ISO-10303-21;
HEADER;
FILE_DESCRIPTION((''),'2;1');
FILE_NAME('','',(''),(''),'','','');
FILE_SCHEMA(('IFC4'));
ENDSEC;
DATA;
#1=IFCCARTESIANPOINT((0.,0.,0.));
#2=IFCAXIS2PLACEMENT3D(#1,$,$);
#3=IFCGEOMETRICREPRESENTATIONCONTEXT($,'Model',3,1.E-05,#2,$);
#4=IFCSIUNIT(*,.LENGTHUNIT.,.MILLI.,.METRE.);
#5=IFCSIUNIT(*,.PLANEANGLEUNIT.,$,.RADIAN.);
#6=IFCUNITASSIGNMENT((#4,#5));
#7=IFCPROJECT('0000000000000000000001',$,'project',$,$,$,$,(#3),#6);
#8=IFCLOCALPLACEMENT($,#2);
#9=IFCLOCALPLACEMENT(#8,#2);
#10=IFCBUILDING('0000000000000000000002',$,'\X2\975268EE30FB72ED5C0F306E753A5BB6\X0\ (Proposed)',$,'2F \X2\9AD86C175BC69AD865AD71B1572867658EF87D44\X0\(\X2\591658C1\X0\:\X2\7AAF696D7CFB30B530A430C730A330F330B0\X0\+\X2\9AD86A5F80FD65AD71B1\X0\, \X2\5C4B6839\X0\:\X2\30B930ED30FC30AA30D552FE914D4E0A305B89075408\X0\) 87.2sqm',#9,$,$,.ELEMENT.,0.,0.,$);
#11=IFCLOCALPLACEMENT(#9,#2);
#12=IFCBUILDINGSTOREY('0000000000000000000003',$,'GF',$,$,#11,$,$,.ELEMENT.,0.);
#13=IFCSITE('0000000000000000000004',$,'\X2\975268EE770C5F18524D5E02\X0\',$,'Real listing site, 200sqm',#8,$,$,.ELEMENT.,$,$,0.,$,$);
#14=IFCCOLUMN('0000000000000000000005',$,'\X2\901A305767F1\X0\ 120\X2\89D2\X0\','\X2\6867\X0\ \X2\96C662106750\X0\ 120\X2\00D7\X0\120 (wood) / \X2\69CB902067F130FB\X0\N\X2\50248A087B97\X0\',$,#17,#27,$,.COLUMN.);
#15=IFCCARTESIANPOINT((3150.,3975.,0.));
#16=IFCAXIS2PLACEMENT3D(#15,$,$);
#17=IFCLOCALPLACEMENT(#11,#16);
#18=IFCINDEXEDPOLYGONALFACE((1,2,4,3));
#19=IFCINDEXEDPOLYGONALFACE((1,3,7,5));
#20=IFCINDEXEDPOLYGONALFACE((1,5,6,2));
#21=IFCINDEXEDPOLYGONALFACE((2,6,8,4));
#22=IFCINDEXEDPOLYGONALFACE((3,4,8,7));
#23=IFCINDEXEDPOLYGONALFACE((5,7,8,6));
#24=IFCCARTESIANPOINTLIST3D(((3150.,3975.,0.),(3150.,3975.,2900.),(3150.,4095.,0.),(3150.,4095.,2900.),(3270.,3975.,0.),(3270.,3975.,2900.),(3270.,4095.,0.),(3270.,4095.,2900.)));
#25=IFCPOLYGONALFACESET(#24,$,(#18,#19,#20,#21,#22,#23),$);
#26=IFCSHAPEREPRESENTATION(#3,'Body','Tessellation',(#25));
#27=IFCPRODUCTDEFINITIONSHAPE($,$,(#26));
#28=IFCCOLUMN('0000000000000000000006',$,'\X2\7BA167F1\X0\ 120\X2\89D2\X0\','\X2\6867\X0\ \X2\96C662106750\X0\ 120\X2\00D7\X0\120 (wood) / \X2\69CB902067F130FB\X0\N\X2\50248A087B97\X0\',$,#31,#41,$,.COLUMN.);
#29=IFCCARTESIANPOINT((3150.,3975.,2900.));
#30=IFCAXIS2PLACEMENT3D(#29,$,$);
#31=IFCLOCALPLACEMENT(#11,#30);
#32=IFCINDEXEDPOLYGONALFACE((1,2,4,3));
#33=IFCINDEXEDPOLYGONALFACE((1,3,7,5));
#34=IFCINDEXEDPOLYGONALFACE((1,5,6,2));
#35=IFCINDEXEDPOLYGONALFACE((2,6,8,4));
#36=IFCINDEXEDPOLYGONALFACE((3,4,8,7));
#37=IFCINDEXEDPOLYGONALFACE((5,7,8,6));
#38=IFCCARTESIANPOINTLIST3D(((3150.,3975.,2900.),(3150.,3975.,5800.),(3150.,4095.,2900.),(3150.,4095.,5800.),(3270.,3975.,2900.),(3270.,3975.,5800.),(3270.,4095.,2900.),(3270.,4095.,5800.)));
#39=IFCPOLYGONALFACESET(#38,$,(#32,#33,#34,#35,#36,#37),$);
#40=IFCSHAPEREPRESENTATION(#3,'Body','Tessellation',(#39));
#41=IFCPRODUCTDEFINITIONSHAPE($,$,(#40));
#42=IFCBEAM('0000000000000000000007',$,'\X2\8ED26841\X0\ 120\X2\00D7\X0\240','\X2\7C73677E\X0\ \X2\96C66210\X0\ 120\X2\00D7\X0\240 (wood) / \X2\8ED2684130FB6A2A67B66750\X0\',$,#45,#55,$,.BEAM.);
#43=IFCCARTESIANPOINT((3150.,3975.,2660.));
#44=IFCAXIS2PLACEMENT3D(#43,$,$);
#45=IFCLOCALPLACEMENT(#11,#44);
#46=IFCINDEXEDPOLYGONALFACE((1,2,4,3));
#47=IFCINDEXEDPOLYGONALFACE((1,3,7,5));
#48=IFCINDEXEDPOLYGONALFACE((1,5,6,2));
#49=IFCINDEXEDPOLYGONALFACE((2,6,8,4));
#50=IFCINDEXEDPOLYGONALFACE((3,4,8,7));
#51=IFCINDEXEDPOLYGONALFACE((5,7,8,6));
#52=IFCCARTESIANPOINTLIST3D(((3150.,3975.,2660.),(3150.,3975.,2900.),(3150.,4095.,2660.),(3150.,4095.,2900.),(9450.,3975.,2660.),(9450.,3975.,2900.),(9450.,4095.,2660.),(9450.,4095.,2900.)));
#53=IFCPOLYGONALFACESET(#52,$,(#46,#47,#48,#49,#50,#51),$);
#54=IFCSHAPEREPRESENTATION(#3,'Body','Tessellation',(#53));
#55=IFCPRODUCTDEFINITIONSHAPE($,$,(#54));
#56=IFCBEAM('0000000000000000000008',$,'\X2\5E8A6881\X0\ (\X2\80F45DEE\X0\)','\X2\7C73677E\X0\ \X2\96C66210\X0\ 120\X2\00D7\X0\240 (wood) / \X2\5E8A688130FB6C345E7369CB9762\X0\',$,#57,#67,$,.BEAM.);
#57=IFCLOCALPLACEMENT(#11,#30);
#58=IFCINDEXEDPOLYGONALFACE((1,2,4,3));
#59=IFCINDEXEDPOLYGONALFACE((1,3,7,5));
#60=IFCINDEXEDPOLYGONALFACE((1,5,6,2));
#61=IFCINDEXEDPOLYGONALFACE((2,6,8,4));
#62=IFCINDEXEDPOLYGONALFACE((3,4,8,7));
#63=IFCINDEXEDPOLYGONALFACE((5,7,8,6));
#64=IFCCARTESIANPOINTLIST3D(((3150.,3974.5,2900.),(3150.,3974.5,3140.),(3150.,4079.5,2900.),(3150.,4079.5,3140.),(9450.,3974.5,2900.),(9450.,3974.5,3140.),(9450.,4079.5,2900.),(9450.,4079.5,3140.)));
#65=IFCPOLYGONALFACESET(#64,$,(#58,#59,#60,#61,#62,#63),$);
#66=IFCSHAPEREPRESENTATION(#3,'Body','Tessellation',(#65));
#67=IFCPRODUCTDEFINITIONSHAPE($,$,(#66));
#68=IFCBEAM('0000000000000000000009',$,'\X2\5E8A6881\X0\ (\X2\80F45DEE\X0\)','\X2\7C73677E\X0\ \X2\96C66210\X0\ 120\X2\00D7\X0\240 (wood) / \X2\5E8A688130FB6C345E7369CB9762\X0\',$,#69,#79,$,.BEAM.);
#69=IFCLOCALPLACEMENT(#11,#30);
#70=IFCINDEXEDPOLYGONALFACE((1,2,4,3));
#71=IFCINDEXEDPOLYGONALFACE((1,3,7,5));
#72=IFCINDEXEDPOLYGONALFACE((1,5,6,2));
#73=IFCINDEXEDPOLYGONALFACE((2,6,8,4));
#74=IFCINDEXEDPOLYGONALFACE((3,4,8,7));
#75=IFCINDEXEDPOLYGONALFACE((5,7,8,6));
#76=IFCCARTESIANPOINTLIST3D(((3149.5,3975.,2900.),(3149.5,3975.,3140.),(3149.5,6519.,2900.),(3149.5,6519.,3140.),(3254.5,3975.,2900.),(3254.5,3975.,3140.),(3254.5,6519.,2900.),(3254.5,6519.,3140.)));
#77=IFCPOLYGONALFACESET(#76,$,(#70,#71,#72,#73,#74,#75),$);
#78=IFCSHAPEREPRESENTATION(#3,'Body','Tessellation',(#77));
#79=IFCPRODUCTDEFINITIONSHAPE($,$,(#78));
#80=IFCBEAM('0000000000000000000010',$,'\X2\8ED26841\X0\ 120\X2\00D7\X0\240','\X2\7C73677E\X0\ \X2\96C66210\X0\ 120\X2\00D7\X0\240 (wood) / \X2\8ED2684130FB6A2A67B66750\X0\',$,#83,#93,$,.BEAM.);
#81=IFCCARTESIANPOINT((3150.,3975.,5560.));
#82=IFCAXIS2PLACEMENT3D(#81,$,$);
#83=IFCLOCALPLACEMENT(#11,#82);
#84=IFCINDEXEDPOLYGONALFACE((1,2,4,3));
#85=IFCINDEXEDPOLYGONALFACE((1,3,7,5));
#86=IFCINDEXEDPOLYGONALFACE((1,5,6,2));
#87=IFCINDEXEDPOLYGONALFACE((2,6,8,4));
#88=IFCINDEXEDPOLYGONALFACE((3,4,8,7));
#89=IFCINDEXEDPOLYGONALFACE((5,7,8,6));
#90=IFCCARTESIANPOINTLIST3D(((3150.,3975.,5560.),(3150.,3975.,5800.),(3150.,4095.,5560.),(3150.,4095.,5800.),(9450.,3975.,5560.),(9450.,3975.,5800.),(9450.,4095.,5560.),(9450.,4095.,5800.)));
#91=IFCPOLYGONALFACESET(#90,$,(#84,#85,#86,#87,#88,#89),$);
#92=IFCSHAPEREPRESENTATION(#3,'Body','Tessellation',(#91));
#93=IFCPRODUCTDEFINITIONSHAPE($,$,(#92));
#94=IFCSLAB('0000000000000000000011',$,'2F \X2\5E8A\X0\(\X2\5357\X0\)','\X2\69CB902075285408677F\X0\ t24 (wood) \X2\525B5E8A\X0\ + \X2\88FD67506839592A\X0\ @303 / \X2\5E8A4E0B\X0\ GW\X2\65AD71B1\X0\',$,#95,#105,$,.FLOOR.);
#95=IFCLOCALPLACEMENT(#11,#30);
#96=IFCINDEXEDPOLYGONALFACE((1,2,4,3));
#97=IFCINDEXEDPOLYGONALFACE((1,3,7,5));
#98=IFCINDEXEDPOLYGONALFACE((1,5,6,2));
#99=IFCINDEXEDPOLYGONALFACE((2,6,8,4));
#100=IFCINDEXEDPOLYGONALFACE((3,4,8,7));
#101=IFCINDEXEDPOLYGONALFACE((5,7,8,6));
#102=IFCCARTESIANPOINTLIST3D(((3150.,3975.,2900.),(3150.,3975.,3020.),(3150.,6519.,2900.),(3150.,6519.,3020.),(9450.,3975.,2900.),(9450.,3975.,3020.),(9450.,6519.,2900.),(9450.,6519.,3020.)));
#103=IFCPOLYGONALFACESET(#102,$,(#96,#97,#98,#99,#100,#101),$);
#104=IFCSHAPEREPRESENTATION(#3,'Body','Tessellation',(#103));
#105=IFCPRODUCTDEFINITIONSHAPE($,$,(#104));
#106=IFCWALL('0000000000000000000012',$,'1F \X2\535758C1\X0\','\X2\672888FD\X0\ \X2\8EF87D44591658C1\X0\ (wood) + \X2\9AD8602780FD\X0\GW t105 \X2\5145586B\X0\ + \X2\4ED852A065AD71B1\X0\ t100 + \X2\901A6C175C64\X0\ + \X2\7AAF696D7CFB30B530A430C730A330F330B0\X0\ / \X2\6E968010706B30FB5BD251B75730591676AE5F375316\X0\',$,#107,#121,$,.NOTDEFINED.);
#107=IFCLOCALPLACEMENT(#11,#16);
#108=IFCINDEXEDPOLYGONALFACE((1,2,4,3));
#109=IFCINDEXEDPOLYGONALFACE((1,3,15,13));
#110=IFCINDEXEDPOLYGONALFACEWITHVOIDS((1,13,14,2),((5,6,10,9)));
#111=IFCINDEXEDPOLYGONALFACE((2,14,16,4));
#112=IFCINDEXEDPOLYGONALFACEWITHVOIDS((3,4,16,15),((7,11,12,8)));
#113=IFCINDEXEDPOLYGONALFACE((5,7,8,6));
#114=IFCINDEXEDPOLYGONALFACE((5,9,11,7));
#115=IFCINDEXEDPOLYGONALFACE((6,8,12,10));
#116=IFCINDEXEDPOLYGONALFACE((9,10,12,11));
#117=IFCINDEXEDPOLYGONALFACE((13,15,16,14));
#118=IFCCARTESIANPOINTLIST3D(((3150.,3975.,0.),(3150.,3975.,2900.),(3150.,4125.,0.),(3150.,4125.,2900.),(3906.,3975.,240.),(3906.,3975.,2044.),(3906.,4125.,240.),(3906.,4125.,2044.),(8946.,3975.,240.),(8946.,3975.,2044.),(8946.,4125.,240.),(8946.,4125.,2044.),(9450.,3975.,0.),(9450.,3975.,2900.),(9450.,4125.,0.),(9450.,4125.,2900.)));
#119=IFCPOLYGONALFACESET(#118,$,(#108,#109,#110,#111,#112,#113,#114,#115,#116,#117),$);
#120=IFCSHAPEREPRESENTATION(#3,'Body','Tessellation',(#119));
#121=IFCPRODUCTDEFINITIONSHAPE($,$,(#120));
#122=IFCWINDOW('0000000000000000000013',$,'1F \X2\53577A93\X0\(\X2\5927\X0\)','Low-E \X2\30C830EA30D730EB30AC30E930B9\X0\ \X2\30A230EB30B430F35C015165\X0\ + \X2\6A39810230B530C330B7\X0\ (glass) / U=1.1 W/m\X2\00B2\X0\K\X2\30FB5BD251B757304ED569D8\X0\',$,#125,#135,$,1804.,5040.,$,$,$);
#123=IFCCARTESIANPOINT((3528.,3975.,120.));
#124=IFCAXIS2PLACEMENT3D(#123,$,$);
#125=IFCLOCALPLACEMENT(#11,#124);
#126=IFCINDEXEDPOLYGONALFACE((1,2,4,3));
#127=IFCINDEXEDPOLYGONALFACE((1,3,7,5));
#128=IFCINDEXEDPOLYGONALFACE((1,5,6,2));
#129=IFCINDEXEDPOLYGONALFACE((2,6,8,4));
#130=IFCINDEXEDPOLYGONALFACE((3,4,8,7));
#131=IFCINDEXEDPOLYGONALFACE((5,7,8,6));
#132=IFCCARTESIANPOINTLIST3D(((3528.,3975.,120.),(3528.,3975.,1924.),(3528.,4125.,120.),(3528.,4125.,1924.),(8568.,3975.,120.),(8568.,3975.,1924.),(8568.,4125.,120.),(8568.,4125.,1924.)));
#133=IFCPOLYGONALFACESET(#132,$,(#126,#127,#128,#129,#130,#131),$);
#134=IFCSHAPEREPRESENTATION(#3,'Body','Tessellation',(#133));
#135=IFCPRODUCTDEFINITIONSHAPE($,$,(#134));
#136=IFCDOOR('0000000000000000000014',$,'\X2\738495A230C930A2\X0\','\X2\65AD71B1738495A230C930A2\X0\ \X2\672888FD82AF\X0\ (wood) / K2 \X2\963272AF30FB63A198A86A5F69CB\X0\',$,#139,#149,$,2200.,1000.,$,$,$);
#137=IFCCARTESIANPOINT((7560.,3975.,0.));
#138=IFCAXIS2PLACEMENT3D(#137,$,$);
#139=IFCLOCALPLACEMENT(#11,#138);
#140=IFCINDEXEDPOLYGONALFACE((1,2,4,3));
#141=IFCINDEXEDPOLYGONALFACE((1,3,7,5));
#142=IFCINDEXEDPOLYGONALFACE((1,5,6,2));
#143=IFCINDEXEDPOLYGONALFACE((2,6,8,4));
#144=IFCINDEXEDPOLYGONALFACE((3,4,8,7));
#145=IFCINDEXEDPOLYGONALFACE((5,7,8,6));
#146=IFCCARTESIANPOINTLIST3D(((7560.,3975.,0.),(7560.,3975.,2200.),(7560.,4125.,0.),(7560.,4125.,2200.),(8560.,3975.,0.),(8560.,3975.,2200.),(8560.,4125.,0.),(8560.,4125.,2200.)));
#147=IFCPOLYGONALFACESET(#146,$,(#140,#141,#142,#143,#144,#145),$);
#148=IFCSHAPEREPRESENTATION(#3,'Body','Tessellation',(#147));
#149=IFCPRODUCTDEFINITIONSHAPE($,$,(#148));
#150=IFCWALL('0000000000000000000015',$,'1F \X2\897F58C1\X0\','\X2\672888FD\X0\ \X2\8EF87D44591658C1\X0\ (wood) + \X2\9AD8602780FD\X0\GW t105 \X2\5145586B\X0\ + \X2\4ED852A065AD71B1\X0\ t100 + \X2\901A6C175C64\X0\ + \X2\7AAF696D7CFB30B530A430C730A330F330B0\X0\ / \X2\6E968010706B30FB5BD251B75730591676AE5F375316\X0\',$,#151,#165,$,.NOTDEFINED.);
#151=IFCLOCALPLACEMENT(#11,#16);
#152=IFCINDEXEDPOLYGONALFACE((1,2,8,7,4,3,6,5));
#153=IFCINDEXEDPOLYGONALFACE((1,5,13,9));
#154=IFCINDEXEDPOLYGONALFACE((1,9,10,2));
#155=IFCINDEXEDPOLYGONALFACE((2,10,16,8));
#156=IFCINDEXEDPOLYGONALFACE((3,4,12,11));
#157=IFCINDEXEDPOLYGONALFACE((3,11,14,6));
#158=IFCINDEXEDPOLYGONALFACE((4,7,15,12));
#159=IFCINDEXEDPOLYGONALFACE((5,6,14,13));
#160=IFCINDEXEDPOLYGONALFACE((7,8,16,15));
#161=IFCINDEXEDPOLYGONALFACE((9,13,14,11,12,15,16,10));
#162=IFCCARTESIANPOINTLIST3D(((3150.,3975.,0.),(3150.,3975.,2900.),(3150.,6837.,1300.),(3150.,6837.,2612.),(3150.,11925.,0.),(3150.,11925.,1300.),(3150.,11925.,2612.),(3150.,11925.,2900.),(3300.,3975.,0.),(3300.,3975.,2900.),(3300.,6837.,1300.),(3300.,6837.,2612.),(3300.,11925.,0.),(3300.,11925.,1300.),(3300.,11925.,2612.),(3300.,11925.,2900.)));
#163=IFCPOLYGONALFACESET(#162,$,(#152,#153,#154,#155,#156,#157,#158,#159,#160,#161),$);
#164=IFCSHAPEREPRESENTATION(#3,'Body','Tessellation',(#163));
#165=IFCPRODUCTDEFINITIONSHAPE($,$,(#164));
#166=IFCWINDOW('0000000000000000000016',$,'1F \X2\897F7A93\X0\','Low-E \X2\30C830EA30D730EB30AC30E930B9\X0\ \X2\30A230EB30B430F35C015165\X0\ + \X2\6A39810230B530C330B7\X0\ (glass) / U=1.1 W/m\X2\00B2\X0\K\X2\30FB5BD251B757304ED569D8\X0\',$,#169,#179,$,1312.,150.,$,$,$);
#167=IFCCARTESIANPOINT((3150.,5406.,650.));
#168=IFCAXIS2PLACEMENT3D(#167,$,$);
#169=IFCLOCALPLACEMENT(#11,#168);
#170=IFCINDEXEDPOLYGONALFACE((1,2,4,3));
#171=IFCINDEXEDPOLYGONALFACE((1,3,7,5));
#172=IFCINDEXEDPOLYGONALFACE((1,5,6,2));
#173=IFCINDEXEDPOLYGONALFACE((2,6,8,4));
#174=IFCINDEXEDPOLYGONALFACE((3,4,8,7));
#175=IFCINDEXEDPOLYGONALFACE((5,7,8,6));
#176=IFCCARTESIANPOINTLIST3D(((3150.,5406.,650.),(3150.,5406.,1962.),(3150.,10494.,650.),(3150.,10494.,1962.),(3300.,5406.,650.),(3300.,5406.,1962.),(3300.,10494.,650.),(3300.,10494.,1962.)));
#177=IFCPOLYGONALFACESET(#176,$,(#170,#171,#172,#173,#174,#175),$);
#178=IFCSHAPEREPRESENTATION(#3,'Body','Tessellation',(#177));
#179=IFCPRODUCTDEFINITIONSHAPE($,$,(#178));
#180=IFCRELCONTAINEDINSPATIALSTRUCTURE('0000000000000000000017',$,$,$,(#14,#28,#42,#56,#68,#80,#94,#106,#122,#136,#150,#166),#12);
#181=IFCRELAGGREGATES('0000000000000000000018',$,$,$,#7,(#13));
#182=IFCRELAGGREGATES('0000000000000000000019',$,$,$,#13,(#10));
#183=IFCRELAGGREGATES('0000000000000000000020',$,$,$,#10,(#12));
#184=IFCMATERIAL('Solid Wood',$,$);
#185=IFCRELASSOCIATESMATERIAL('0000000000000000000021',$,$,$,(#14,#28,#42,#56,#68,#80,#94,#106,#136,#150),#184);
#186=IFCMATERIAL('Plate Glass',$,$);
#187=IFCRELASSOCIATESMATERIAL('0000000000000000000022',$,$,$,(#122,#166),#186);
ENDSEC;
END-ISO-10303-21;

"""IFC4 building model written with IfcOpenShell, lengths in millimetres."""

from ifc_helpers import new_model, si_unit, frame, frame_2d, origin, place, context, project, spatial, rectangle, extrude, material, element, fill, save


model = new_model("IFC4")

# Units and contexts
model_context = context("Model", 3, precision=1e-05, world=origin())
ifc_project = project(units=[si_unit("LENGTHUNIT", "METRE", prefix="MILLI"), si_unit("PLANEANGLEUNIT", "RADIAN")], contexts=[model_context])

# Site, building, storey
site_placement = place(None, origin())
site = spatial("IfcSite", under=ifc_project, at=site_placement, Name="青森県弘前市", ObjectType="Real listing site, 200sqm", CompositionType="ELEMENT", RefElevation=0.0)
building_placement = place(site_placement, origin())
building = spatial("IfcBuilding", under=site, at=building_placement, Name="青森・狭小の町家 (Proposed)", ObjectType="2F 高気密高断熱在来軸組(外壁:窯業系サイディング+高機能断熱, 屋根:スローオフ勾配上せ複合) 87.2sqm", CompositionType="ELEMENT", ElevationOfRefHeight=0.0, ElevationOfTerrain=0.0)
storey_placement = place(building_placement, origin())
storey = spatial("IfcBuildingStorey", under=building, at=storey_placement, Name="GF", CompositionType="ELEMENT", Elevation=0.0)

# Columns
ifc_material_1 = material(Name="Solid Wood")
column_1_placement = place(storey_placement, frame((3150.0, 3975.0, 0.0)))
element("IfcColumn", 1, at=column_1_placement, inside=storey, material=ifc_material_1, Name="通し柱 120角", Description="桧 集成材 120×120 (wood) / 構造柱・N値計算", PredefinedType="COLUMN", context=model_context, shape_type="SweptSolid", body=[
    extrude(rectangle(XDim=120.0, YDim=120.0, at=frame_2d((60.0, 60.0))), frame((3150.0, 3975.0, 0.0)), (0.0, 0.0, 1.0), 2900.0),
])
column_2_placement = place(storey_placement, frame((3150.0, 3975.0, 2900.0)))
element("IfcColumn", 2, at=column_2_placement, inside=storey, material=ifc_material_1, Name="管柱 120角", Description="桧 集成材 120×120 (wood) / 構造柱・N値計算", PredefinedType="COLUMN", context=model_context, shape_type="SweptSolid", body=[
    extrude(rectangle(XDim=120.0, YDim=120.0, at=frame_2d((60.0, 60.0))), frame((3150.0, 3975.0, 2900.0)), (0.0, 0.0, 1.0), 2900.0),
])

# Beams
beam_1_placement = place(storey_placement, frame((3150.0, 3975.0, 2660.0)))
element("IfcBeam", 3, at=beam_1_placement, inside=storey, material=ifc_material_1, Name="軒桁 120×240", Description="米松 集成 120×240 (wood) / 軒桁・横架材", PredefinedType="BEAM", context=model_context, shape_type="SweptSolid", body=[
    extrude(rectangle(XDim=6300.0, YDim=120.0, at=frame_2d((3150.0, 60.0))), frame((3150.0, 3975.0, 2660.0)), (0.0, 0.0, 1.0), 240.0),
])
beam_2_placement = place(storey_placement, frame((3150.0, 3975.0, 2900.0)))
element("IfcBeam", 4, at=beam_2_placement, inside=storey, material=ifc_material_1, Name="床梁 (胴差)", Description="米松 集成 120×240 (wood) / 床梁・水平構面", PredefinedType="BEAM", context=model_context, shape_type="SweptSolid", body=[
    extrude(rectangle(XDim=6300.0, YDim=105.0, at=frame_2d((3150.0, 52.0))), frame((3150.0, 3975.0, 2900.0)), (0.0, 0.0, 1.0), 240.0),
])
beam_3_placement = place(storey_placement, frame((3150.0, 3975.0, 2900.0)))
element("IfcBeam", 5, at=beam_3_placement, inside=storey, material=ifc_material_1, Name="床梁 (胴差)", Description="米松 集成 120×240 (wood) / 床梁・水平構面", PredefinedType="BEAM", context=model_context, shape_type="SweptSolid", body=[
    extrude(rectangle(XDim=105.0, YDim=2544.0, at=frame_2d((52.0, 1272.0))), frame((3150.0, 3975.0, 2900.0)), (0.0, 0.0, 1.0), 240.0),
])
beam_4_placement = place(storey_placement, frame((3150.0, 3975.0, 5560.0)))
element("IfcBeam", 6, at=beam_4_placement, inside=storey, material=ifc_material_1, Name="軒桁 120×240", Description="米松 集成 120×240 (wood) / 軒桁・横架材", PredefinedType="BEAM", context=model_context, shape_type="SweptSolid", body=[
    extrude(rectangle(XDim=6300.0, YDim=120.0, at=frame_2d((3150.0, 60.0))), frame((3150.0, 3975.0, 5560.0)), (0.0, 0.0, 1.0), 240.0),
])

# Slab
slab_1_placement = place(storey_placement, frame((3150.0, 3975.0, 2900.0)))
element("IfcSlab", 7, at=slab_1_placement, inside=storey, material=ifc_material_1, Name="2F 床(南)", Description="構造用合板 t24 (wood) 剛床 + 製材根太 @303 / 床下 GW断熱", PredefinedType="FLOOR", context=model_context, shape_type="SweptSolid", body=[
    extrude(rectangle(XDim=6300.0, YDim=2544.0, at=frame_2d((3150.0, 1272.0))), frame((3150.0, 3975.0, 2900.0)), (0.0, 0.0, 1.0), 120.0),
])

# Wall, openings, window, door
wall_1_placement = place(storey_placement, frame((3150.0, 3975.0, 0.0)))
wall_1 = element("IfcWall", 8, at=wall_1_placement, inside=storey, material=ifc_material_1, Name="1F 南壁", Description="木製 軸組外壁 (wood) + 高性能GW t105 充填 + 付加断熱 t100 + 通気層 + 窯業系サイディング / 準耐火・寒冷地外皮強化", PredefinedType="NOTDEFINED", context=model_context, shape_type="SweptSolid", body=[
    extrude(rectangle(XDim=6300.0, YDim=150.0, at=frame_2d((3150.0, 75.0))), frame((3150.0, 3975.0, 0.0)), (0.0, 0.0, 1.0), 2900.0),
])
opening_1_placement = place(storey_placement, frame((3528.0, 3975.0, 120.0)))
opening_1 = element("IfcOpeningElement", 9, at=opening_1_placement, cuts=wall_1, PredefinedType="NOTDEFINED", context=model_context, shape_type="SweptSolid", body=[
    extrude(rectangle(XDim=5040.0, YDim=150.0, at=frame_2d((2520.0, 75.0))), frame((3528.0, 3975.0, 120.0)), (0.0, 0.0, 1.0), 1804.0),
])
opening_2_placement = place(storey_placement, frame((7560.0, 3975.0, 0.0)))
opening_2 = element("IfcOpeningElement", 10, at=opening_2_placement, cuts=wall_1, PredefinedType="NOTDEFINED", context=model_context, shape_type="SweptSolid", body=[
    extrude(rectangle(XDim=1000.0, YDim=150.0, at=frame_2d((500.0, 75.0))), frame((7560.0, 3975.0, 0.0)), (0.0, 0.0, 1.0), 2200.0),
])
ifc_material_2 = material(Name="Plate Glass")
window_1_placement = place(storey_placement, frame((3528.0, 3975.0, 120.0)))
window_1 = element("IfcWindow", 11, at=window_1_placement, inside=storey, material=ifc_material_2, Name="1F 南窓(大)", Description="Low-E トリプルガラス アルゴン封入 + 樹脂サッシ (glass) / U=1.1 W/m²K・寒冷地仕様", OverallHeight=1804.0, OverallWidth=5040.0, context=model_context, shape_type="SweptSolid", body=[
    extrude(rectangle(XDim=5040.0, YDim=150.0, at=frame_2d((2520.0, 75.0))), frame((3528.0, 3975.0, 120.0)), (0.0, 0.0, 1.0), 1804.0),
])
fill(opening_1, window_1)
door_placement = place(storey_placement, frame((7560.0, 3975.0, 0.0)))
door = element("IfcDoor", 12, at=door_placement, inside=storey, material=ifc_material_1, Name="玄関ドア", Description="断熱玄関ドア 木製芯 (wood) / K2 防犯・採風機構", OverallHeight=2200.0, OverallWidth=1000.0, context=model_context, shape_type="SweptSolid", body=[
    extrude(rectangle(XDim=1000.0, YDim=150.0, at=frame_2d((500.0, 75.0))), frame((7560.0, 3975.0, 0.0)), (0.0, 0.0, 1.0), 2200.0),
])
fill(opening_2, door)

# Wall, opening, window
wall_2_placement = place(storey_placement, frame((3150.0, 3975.0, 0.0)))
wall_2 = element("IfcWall", 13, at=wall_2_placement, inside=storey, material=ifc_material_1, Name="1F 西壁", Description="木製 軸組外壁 (wood) + 高性能GW t105 充填 + 付加断熱 t100 + 通気層 + 窯業系サイディング / 準耐火・寒冷地外皮強化", PredefinedType="NOTDEFINED", context=model_context, shape_type="SweptSolid", body=[
    extrude(rectangle(XDim=150.0, YDim=7950.0, at=frame_2d((75.0, 3975.0))), frame((3150.0, 3975.0, 0.0)), (0.0, 0.0, 1.0), 2900.0),
])
opening_3_placement = place(storey_placement, frame((3150.0, 5406.0, 650.0)))
opening_3 = element("IfcOpeningElement", 14, at=opening_3_placement, cuts=wall_2, PredefinedType="NOTDEFINED", context=model_context, shape_type="SweptSolid", body=[
    extrude(rectangle(XDim=150.0, YDim=5088.0, at=frame_2d((75.0, 2544.0))), frame((3150.0, 5406.0, 650.0)), (0.0, 0.0, 1.0), 1312.0),
])
window_2_placement = place(storey_placement, frame((3150.0, 5406.0, 650.0)))
window_2 = element("IfcWindow", 15, at=window_2_placement, inside=storey, material=ifc_material_2, Name="1F 西窓", Description="Low-E トリプルガラス アルゴン封入 + 樹脂サッシ (glass) / U=1.1 W/m²K・寒冷地仕様", OverallHeight=1312.0, OverallWidth=150.0, context=model_context, shape_type="SweptSolid", body=[
    extrude(rectangle(XDim=150.0, YDim=5088.0, at=frame_2d((75.0, 2544.0))), frame((3150.0, 5406.0, 650.0)), (0.0, 0.0, 1.0), 1312.0),
])
fill(opening_3, window_2)

save(model, "model.ifc")
